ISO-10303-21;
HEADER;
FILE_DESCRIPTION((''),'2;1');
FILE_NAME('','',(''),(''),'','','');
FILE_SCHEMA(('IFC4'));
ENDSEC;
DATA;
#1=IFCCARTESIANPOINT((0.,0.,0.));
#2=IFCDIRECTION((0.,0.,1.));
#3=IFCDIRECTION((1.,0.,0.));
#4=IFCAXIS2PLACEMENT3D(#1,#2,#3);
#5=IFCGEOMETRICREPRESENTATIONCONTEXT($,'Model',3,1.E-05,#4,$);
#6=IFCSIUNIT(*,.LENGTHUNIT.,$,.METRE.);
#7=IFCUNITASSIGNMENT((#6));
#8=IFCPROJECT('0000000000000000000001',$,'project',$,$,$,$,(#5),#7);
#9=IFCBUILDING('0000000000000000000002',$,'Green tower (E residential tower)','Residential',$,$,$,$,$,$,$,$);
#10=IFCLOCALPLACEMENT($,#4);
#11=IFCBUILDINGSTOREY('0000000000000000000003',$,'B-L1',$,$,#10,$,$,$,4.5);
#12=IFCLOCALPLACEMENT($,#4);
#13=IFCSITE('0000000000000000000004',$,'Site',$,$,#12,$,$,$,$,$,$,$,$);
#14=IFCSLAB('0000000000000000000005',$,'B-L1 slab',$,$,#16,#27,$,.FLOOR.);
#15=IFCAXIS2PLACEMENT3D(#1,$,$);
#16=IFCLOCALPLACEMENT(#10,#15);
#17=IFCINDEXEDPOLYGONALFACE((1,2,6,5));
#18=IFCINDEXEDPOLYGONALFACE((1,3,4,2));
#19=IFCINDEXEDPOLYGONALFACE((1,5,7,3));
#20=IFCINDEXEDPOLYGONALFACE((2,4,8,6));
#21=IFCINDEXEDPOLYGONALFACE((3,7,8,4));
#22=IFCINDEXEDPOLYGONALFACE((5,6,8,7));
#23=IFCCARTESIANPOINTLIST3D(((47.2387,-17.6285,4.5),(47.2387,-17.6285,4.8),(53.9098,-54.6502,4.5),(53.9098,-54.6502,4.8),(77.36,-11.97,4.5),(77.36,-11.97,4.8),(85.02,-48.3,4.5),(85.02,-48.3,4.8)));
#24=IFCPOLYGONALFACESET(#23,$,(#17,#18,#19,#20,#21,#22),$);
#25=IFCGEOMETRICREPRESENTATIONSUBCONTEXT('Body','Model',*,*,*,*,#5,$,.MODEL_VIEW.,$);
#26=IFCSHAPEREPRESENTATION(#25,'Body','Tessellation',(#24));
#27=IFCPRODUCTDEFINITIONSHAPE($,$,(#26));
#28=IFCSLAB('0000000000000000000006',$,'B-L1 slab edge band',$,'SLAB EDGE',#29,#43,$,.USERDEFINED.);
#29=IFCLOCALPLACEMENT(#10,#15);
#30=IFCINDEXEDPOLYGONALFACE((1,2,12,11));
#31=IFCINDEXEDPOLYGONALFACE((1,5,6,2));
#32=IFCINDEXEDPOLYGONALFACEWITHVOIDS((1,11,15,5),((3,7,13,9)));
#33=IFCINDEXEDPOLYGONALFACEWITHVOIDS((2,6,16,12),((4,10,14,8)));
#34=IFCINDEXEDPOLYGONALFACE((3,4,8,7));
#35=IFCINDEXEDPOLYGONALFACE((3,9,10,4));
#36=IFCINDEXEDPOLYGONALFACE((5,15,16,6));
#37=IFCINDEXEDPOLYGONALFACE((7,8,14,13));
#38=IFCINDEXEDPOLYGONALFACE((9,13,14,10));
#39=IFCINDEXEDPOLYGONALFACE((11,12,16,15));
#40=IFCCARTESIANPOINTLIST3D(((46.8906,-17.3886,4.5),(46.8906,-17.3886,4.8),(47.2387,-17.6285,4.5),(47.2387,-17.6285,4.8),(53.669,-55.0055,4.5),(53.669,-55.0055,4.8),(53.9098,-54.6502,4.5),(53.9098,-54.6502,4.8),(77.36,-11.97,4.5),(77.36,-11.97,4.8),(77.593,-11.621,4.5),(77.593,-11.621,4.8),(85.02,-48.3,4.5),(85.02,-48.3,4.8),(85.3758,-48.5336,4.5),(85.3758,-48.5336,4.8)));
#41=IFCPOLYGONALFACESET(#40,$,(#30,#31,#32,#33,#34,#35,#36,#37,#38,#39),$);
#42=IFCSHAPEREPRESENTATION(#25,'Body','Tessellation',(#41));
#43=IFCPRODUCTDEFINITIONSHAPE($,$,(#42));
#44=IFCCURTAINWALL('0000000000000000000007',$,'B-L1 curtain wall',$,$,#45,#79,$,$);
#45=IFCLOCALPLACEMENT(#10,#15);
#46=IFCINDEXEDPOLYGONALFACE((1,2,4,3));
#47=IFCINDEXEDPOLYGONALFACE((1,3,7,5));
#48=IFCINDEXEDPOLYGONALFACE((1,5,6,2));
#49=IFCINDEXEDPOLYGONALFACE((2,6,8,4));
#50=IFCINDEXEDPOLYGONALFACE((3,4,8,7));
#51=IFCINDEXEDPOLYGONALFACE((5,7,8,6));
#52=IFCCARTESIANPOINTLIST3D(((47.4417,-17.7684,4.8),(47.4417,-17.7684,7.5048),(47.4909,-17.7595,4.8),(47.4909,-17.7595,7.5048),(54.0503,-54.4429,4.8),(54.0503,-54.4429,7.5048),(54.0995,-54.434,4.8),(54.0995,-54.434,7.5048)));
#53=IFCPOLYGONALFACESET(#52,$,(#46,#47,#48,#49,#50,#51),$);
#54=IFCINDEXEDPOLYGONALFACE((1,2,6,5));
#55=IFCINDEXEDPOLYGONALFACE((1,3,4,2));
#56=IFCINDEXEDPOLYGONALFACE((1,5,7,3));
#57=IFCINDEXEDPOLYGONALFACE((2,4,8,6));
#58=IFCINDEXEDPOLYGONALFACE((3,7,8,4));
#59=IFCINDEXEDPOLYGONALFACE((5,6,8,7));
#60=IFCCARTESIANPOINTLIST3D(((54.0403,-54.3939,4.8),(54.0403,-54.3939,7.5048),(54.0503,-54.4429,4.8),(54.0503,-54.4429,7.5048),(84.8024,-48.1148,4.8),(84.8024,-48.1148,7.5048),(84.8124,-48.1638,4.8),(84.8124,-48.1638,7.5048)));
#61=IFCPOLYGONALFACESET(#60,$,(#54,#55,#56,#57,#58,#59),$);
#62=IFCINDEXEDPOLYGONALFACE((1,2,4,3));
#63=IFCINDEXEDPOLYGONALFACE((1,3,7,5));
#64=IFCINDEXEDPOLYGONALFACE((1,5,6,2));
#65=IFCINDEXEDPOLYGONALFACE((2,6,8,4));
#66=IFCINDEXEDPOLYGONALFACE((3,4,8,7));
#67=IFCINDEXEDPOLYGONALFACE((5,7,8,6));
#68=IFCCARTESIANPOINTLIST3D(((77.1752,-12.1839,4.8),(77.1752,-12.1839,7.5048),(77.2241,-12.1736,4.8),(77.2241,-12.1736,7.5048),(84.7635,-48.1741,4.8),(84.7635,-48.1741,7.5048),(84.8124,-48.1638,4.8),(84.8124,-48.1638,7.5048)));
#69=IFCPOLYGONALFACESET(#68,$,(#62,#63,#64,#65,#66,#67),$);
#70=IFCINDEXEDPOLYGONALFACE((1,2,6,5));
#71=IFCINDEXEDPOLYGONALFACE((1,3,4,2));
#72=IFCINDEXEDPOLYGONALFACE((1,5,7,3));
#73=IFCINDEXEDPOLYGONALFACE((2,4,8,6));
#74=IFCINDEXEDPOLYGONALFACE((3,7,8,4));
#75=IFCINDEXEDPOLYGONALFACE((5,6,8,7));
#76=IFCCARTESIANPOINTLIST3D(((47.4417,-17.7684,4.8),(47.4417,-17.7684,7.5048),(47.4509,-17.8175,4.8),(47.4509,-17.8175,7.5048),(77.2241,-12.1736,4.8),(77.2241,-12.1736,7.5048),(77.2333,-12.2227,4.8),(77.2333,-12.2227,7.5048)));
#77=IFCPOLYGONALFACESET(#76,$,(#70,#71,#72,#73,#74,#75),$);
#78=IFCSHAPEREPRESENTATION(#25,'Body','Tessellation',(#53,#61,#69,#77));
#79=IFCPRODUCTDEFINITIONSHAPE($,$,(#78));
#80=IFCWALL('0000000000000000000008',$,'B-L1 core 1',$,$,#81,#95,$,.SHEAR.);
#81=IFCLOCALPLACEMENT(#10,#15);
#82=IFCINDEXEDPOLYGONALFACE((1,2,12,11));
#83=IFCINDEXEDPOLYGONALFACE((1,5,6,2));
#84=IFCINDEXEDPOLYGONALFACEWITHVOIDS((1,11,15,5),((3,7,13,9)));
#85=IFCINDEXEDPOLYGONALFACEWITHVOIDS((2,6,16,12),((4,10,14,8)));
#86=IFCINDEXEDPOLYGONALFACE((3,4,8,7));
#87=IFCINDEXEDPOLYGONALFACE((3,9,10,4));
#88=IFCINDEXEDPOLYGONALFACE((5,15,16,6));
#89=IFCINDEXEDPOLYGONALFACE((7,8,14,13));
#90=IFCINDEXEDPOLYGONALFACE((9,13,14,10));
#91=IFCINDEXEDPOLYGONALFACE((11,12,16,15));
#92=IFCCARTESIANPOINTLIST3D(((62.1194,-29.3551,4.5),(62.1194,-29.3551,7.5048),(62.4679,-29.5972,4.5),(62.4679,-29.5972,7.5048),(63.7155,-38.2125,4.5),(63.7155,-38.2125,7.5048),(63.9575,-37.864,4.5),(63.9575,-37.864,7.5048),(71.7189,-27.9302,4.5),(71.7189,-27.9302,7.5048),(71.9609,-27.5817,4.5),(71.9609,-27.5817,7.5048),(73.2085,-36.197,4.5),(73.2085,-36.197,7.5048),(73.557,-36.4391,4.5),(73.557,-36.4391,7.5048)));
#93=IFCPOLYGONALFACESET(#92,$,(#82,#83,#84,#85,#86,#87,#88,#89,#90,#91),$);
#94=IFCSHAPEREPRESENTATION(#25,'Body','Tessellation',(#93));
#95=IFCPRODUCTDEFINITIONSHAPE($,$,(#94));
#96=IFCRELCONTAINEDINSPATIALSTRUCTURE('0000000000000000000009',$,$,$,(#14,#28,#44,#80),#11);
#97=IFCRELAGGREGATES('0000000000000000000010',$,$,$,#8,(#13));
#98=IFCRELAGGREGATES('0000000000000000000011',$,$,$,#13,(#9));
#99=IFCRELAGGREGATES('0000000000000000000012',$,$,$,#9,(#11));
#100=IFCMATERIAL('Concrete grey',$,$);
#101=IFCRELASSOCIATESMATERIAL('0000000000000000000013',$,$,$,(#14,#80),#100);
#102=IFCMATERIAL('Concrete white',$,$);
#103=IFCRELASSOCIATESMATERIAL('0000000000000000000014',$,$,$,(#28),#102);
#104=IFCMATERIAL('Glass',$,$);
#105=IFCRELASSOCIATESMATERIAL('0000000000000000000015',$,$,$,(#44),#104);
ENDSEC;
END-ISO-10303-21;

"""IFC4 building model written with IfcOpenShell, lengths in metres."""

from ifc_helpers import new_model, si_unit, frame, origin_with_axes, place, context, subcontext, project, spatial, polyline, outline, extrude, material, element, save


model = new_model("IFC4")

# Units and contexts
model_context = context("Model", 3, precision=1e-05, world=origin_with_axes())
body_context = subcontext(model_context, "Body", "Model", "MODEL_VIEW")
ifc_project = project(units=[si_unit("LENGTHUNIT", "METRE")], contexts=[model_context])

# Site, building, storey
site_placement = place(None, origin_with_axes())
site = spatial("IfcSite", under=ifc_project, at=site_placement, Name="Site")
building = spatial("IfcBuilding", under=site, Name="Green tower (E residential tower)", Description="Residential")
storey_placement = place(None, origin_with_axes())
storey = spatial("IfcBuildingStorey", under=building, at=storey_placement, Name="B-L1", Elevation=4.5)

# Slabs
ifc_material_1 = material(Name="Concrete grey")
slab_1_placement = place(storey_placement, origin_with_axes())
element("IfcSlab", 1, at=slab_1_placement, inside=storey, material=ifc_material_1, Name="B-L1 slab", PredefinedType="FLOOR", context=body_context, shape_type="SweptSolid", body=[
    extrude(outline(polyline([(47.2387, -17.6285), (53.9098, -54.6502), (85.02, -48.3), (77.36, -11.97), (47.2387, -17.6285)])), frame((0.0, 0.0, 4.5), z_axis=(0.0, 0.0, 1.0), x_axis=(1.0, 0.0, 0.0)), (0.0, 0.0, 1.0), 0.3),
])
ifc_material_2 = material(Name="Concrete white")
slab_2_placement = place(storey_placement, origin_with_axes())
element("IfcSlab", 2, at=slab_2_placement, inside=storey, material=ifc_material_2, Name="B-L1 slab edge band", ObjectType="SLAB EDGE", PredefinedType="USERDEFINED", context=body_context, shape_type="SweptSolid", body=[
    extrude(outline(polyline([(46.8906, -17.3886), (53.669, -55.0055), (85.3758, -48.5336), (77.593, -11.621), (46.8906, -17.3886)]), holes=[polyline([(47.2387, -17.6285), (53.9098, -54.6502), (85.02, -48.3), (77.36, -11.97), (47.2387, -17.6285)])]), frame((0.0, 0.0, 4.5), z_axis=(0.0, 0.0, 1.0), x_axis=(1.0, 0.0, 0.0)), (0.0, 0.0, 1.0), 0.3),
])

# Curtain wall
ifc_material_3 = material(Name="Glass")
curtain_wall_placement = place(storey_placement, origin_with_axes())
element("IfcCurtainWall", 3, at=curtain_wall_placement, inside=storey, material=ifc_material_3, Name="B-L1 curtain wall", context=body_context, shape_type="SweptSolid", body=[
    extrude(outline(polyline([(47.4417, -17.7684), (54.0503, -54.4429), (54.0995, -54.434), (47.4909, -17.7595), (47.4417, -17.7684)])), frame((0.0, 0.0, 4.8), z_axis=(0.0, 0.0, 1.0), x_axis=(1.0, 0.0, 0.0)), (0.0, 0.0, 1.0), 2.7048),
    extrude(outline(polyline([(54.0503, -54.4429), (84.8124, -48.1638), (84.8024, -48.1148), (54.0403, -54.3939), (54.0503, -54.4429)])), frame((0.0, 0.0, 4.8), z_axis=(0.0, 0.0, 1.0), x_axis=(1.0, 0.0, 0.0)), (0.0, 0.0, 1.0), 2.7048),
    extrude(outline(polyline([(84.8124, -48.1638), (77.2241, -12.1736), (77.1752, -12.1839), (84.7635, -48.1741), (84.8124, -48.1638)])), frame((0.0, 0.0, 4.8), z_axis=(0.0, 0.0, 1.0), x_axis=(1.0, 0.0, 0.0)), (0.0, 0.0, 1.0), 2.7048),
    extrude(outline(polyline([(77.2241, -12.1736), (47.4417, -17.7684), (47.4509, -17.8175), (77.2333, -12.2227), (77.2241, -12.1736)])), frame((0.0, 0.0, 4.8), z_axis=(0.0, 0.0, 1.0), x_axis=(1.0, 0.0, 0.0)), (0.0, 0.0, 1.0), 2.7048),
])

# Wall
wall_placement = place(storey_placement, origin_with_axes())
element("IfcWall", 4, at=wall_placement, inside=storey, material=ifc_material_1, Name="B-L1 core 1", PredefinedType="SHEAR", context=body_context, shape_type="SweptSolid", body=[
    extrude(outline(polyline([(62.1194, -29.3551), (63.7155, -38.2125), (73.557, -36.4391), (71.9609, -27.5817), (62.1194, -29.3551)]), holes=[polyline([(62.4679, -29.5972), (63.9575, -37.864), (73.2085, -36.197), (71.7189, -27.9302), (62.4679, -29.5972)])]), frame((0.0, 0.0, 4.5), z_axis=(0.0, 0.0, 1.0), x_axis=(1.0, 0.0, 0.0)), (0.0, 0.0, 1.0), 3.0048),
])

save(model, "model.ifc")
